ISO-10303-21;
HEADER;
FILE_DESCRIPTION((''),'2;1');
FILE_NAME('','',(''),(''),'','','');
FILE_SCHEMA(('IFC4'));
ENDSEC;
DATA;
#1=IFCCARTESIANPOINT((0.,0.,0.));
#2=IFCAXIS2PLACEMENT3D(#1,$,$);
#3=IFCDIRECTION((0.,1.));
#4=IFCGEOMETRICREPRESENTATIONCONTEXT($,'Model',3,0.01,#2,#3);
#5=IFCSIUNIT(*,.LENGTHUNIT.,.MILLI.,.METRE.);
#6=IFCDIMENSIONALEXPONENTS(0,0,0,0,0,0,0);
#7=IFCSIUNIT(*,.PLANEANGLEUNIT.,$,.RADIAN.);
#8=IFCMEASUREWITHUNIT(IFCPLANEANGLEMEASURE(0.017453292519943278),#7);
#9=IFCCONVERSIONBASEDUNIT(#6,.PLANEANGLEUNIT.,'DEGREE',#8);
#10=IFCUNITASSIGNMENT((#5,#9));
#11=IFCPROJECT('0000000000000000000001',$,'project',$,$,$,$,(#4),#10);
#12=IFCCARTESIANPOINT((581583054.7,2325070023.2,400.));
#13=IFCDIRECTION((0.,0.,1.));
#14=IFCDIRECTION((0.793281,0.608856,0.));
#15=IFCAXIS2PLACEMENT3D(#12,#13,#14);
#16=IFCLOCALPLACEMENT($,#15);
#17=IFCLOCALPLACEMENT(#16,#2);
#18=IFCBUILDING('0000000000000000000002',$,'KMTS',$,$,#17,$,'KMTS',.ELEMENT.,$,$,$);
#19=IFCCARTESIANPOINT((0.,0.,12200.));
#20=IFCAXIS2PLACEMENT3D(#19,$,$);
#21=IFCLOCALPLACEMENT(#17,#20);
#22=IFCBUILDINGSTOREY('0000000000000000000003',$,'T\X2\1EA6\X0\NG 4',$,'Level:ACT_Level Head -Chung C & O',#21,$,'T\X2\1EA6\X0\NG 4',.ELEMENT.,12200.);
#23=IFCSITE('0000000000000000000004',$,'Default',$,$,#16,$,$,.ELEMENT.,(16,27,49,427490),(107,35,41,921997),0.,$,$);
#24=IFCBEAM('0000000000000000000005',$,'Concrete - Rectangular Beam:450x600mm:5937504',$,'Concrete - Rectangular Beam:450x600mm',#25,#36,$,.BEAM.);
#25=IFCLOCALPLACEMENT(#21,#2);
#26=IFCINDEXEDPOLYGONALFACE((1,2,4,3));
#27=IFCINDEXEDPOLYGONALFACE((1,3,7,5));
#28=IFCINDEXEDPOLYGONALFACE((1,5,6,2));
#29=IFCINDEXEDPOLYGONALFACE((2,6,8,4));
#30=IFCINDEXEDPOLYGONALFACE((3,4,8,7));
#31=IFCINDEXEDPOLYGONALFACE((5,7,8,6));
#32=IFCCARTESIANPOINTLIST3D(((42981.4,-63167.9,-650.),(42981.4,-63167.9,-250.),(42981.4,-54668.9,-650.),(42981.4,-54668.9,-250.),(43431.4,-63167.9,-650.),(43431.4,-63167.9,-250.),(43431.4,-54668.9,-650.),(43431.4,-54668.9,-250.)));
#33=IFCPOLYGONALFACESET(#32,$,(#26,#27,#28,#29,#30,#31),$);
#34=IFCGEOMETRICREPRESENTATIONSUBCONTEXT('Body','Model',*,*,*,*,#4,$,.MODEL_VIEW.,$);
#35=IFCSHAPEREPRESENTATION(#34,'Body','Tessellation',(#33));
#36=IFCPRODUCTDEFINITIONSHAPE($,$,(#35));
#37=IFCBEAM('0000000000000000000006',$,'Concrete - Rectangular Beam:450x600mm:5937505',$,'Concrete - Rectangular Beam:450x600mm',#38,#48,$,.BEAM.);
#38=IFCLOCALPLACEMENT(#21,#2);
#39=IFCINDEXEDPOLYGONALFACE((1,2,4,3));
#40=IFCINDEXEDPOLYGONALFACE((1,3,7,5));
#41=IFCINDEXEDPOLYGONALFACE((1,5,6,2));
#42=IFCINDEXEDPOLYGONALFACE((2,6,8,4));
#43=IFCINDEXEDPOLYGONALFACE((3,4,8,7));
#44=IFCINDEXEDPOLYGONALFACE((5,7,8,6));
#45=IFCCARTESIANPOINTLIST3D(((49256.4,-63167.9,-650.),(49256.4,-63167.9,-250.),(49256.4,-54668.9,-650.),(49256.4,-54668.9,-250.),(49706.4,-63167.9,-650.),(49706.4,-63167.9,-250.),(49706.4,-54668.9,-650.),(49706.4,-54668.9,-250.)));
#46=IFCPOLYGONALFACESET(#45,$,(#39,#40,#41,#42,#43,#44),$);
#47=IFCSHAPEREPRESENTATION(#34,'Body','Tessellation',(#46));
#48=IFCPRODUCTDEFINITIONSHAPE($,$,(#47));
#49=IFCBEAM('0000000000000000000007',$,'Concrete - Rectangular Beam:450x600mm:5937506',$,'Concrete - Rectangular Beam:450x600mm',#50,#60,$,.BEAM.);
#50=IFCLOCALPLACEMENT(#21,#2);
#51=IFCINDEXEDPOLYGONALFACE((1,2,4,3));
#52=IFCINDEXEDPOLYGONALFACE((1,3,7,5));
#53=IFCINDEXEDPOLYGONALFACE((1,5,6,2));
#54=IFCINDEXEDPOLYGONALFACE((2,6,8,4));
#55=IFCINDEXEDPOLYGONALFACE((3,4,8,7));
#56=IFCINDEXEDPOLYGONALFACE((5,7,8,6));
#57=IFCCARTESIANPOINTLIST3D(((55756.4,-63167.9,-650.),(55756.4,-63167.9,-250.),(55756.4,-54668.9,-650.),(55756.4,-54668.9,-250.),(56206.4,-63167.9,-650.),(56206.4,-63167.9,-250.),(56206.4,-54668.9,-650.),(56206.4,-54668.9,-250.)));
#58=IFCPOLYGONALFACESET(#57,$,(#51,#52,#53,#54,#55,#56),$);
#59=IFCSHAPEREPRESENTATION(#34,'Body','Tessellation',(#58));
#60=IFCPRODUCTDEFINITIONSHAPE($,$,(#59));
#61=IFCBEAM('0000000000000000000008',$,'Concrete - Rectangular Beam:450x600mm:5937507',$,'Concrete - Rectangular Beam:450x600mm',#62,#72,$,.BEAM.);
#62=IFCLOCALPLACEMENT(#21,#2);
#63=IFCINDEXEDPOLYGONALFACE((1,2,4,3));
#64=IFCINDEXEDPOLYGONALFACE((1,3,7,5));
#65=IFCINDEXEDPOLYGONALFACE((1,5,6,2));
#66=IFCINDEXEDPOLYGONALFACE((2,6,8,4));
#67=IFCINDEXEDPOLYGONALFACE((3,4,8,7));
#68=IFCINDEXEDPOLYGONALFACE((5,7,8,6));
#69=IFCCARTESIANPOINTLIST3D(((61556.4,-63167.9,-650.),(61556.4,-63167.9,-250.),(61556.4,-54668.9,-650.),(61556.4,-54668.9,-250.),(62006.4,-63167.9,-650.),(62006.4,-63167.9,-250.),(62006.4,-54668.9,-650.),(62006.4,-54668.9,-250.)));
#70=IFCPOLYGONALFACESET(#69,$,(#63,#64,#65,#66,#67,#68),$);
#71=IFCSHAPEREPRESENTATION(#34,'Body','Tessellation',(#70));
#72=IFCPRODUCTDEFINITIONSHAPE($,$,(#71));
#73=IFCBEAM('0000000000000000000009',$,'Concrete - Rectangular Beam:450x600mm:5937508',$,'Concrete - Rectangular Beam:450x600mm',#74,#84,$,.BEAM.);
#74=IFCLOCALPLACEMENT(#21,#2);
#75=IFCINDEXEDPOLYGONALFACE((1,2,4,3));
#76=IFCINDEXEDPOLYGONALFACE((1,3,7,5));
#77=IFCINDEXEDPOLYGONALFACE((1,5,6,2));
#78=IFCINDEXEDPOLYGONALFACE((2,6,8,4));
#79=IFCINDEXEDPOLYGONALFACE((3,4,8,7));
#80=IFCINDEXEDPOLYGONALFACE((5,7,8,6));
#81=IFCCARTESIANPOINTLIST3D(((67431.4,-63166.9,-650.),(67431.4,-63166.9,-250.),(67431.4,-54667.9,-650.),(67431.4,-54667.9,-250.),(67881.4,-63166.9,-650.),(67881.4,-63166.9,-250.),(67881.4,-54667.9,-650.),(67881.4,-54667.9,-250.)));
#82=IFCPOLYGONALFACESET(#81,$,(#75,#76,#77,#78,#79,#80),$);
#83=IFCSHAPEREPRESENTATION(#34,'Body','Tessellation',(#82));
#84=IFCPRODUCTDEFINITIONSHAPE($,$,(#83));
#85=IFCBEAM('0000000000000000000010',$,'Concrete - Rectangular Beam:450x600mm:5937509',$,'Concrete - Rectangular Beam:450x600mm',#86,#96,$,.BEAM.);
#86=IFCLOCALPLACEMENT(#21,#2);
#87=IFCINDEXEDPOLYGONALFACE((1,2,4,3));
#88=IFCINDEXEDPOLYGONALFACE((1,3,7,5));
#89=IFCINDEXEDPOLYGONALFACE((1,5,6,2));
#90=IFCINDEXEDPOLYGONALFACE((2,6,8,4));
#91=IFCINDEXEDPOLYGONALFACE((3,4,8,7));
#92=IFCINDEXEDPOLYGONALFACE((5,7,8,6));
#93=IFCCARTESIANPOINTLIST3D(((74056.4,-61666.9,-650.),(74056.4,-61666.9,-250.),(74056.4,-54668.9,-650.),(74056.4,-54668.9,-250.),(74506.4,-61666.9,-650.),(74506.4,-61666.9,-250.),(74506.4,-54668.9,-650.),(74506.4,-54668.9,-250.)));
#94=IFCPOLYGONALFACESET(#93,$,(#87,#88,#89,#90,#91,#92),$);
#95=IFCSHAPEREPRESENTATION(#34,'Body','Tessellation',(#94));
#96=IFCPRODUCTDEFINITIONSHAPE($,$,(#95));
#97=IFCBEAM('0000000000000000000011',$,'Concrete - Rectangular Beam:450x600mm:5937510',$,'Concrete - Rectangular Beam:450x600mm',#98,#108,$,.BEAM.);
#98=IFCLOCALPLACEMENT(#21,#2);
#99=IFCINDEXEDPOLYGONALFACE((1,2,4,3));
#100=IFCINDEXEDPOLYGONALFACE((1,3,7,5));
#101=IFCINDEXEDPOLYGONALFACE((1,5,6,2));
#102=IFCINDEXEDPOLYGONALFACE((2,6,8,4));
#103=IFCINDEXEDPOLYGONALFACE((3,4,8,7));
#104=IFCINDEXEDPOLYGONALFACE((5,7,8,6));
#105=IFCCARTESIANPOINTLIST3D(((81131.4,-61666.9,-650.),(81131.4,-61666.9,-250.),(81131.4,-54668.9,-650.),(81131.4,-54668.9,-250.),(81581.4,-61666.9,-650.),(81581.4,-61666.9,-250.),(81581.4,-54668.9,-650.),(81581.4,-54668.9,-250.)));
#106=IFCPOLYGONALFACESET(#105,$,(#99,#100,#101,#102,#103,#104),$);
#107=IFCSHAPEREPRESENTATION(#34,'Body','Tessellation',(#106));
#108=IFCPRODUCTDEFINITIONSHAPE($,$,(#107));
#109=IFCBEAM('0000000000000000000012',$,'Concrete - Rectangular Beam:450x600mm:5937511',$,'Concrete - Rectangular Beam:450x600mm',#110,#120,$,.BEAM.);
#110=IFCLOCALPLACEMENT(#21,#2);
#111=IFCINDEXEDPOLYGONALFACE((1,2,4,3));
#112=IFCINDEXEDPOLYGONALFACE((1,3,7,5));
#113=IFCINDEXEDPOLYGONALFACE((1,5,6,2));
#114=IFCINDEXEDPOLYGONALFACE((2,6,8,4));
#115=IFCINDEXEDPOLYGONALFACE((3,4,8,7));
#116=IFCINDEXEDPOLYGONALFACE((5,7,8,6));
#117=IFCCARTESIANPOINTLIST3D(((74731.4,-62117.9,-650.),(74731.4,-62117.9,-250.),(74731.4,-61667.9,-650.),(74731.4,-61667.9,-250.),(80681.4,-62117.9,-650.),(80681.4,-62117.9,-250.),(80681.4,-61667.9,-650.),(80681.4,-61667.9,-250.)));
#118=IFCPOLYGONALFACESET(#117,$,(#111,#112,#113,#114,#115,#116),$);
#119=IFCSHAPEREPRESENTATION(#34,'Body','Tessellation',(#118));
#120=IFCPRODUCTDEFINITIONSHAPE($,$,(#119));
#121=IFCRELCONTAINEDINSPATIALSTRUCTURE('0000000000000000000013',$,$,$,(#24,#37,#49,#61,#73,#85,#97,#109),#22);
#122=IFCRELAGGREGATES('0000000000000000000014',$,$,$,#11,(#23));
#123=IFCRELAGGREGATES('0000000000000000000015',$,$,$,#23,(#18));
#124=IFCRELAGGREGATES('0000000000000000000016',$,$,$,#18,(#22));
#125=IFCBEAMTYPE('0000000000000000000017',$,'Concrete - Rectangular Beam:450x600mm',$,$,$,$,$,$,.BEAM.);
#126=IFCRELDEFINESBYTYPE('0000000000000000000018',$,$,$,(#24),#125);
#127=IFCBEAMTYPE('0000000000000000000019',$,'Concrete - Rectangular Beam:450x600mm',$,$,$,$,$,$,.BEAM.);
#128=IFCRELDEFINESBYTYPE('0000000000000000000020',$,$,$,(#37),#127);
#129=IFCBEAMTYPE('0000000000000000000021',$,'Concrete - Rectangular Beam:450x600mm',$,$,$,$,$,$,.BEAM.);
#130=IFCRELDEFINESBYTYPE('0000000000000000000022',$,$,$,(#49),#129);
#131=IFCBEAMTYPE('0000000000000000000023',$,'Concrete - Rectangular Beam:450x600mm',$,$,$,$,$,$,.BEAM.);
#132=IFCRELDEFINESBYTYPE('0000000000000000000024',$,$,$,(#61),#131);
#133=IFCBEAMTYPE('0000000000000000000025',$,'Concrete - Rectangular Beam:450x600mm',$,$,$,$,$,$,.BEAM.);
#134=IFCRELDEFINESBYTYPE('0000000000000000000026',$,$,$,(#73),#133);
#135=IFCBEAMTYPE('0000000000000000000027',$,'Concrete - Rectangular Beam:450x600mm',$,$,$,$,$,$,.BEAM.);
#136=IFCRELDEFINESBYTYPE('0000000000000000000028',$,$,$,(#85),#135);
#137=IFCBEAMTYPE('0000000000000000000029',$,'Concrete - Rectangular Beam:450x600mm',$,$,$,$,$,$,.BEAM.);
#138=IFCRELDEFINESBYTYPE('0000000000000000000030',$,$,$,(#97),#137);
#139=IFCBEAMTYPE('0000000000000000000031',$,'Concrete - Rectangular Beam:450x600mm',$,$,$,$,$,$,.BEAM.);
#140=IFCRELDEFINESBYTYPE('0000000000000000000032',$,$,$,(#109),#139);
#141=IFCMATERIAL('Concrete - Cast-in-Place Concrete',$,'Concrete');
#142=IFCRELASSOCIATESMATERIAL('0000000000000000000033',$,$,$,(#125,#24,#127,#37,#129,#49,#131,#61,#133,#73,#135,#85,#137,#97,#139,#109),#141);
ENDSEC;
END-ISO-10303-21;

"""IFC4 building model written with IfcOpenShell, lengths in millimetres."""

from ifc_helpers import new_model, entity, si_unit, converted_unit, direction, frame, origin, place, context, subcontext, project, spatial, indexed_curve, outline, extrude, source, transform, mapped, material, type_object, type_shapes, element, save


model = new_model("IFC4")

# Units and contexts
model_context = context("Model", 3, precision=0.01, world=origin(), true_north=direction((0.0, 1.0)))
body_context = subcontext(model_context, "Body", "Model", "MODEL_VIEW")
ifc_project = project(units=[si_unit("LENGTHUNIT", "METRE", prefix="MILLI"), converted_unit("PLANEANGLEUNIT", "DEGREE", entity("IfcPlaneAngleMeasure", 0.017453292519943278), si_unit("PLANEANGLEUNIT", "RADIAN"), dimensions=[0, 0, 0, 0, 0, 0, 0])], contexts=[model_context])

# Site, building, storey
site_placement = place(None, frame((581583054.7, 2325070023.2, 400.0), z_axis=(0.0, 0.0, 1.0), x_axis=(0.793281, 0.608856, 0.0)))
site = spatial("IfcSite", under=ifc_project, at=site_placement, Name="Default", CompositionType="ELEMENT", RefLatitude=(16, 27, 49, 427490), RefLongitude=(107, 35, 41, 921997), RefElevation=0.0)
building_placement = place(site_placement, origin())
building = spatial("IfcBuilding", under=site, at=building_placement, Name="KMTS", LongName="KMTS", CompositionType="ELEMENT")
storey_placement = place(building_placement, frame((0.0, 0.0, 12200.0)))
storey = spatial("IfcBuildingStorey", under=building, at=storey_placement, Name="TẦNG 4", ObjectType="Level:ACT_Level Head -Chung C & O", LongName="TẦNG 4", CompositionType="ELEMENT", Elevation=12200.0)

# Beams
ifc_material = material(Name="Concrete - Cast-in-Place Concrete", Category="Concrete")
beam_type_1 = type_object("IfcBeamType", Name="Concrete - Rectangular Beam:450x600mm", PredefinedType="BEAM", material=ifc_material)
shared_shape_1 = source(origin(), body_context, "Body", "SweptSolid", [
    extrude(outline(indexed_curve([(-225.0, -200.0), (225.0, -200.0), (225.0, 200.0), (-225.0, 200.0), (-225.0, -200.0)], self_intersect=False)), frame((43206.4, -54668.9, 11750.0), z_axis=(0.0, -1.0, 0.0), x_axis=(-1.0, 0.0, 0.0)), (0.0, 0.0, 1.0), 8499.0),
])
type_shapes(beam_type_1, [shared_shape_1])
beam_1_placement = place(storey_placement, frame((0.0, 0.0, -12200.0)))
element("IfcBeam", 1, at=beam_1_placement, inside=storey, type_object=beam_type_1, material=ifc_material, Name="Concrete - Rectangular Beam:450x600mm:5937504", ObjectType="Concrete - Rectangular Beam:450x600mm", PredefinedType="BEAM", context=body_context, shape_type="MappedRepresentation", body=[
    mapped(shared_shape_1, transform((0.0, 0.0, 0.0), scale=1.0)),
])
beam_type_2 = type_object("IfcBeamType", Name="Concrete - Rectangular Beam:450x600mm", PredefinedType="BEAM", material=ifc_material)
shared_shape_2 = source(origin(), body_context, "Body", "SweptSolid", [
    extrude(outline(indexed_curve([(-225.0, -200.0), (225.0, -200.0), (225.0, 200.0), (-225.0, 200.0), (-225.0, -200.0)], self_intersect=False)), frame((49481.4, -54668.9, 11750.0), z_axis=(0.0, -1.0, 0.0), x_axis=(-1.0, 0.0, 0.0)), (0.0, 0.0, 1.0), 8499.0),
])
type_shapes(beam_type_2, [shared_shape_2])
beam_2_placement = place(storey_placement, frame((0.0, 0.0, -12200.0)))
element("IfcBeam", 2, at=beam_2_placement, inside=storey, type_object=beam_type_2, material=ifc_material, Name="Concrete - Rectangular Beam:450x600mm:5937505", ObjectType="Concrete - Rectangular Beam:450x600mm", PredefinedType="BEAM", context=body_context, shape_type="MappedRepresentation", body=[
    mapped(shared_shape_2, transform((0.0, 0.0, 0.0), scale=1.0)),
])
beam_type_3 = type_object("IfcBeamType", Name="Concrete - Rectangular Beam:450x600mm", PredefinedType="BEAM", material=ifc_material)
shared_shape_3 = source(origin(), body_context, "Body", "SweptSolid", [
    extrude(outline(indexed_curve([(-225.0, -200.0), (225.0, -200.0), (225.0, 200.0), (-225.0, 200.0), (-225.0, -200.0)], self_intersect=False)), frame((55981.4, -54668.9, 11750.0), z_axis=(0.0, -1.0, 0.0), x_axis=(-1.0, 0.0, 0.0)), (0.0, 0.0, 1.0), 8499.0),
])
type_shapes(beam_type_3, [shared_shape_3])
beam_3_placement = place(storey_placement, frame((0.0, 0.0, -12200.0)))
element("IfcBeam", 3, at=beam_3_placement, inside=storey, type_object=beam_type_3, material=ifc_material, Name="Concrete - Rectangular Beam:450x600mm:5937506", ObjectType="Concrete - Rectangular Beam:450x600mm", PredefinedType="BEAM", context=body_context, shape_type="MappedRepresentation", body=[
    mapped(shared_shape_3, transform((0.0, 0.0, 0.0), scale=1.0)),
])
beam_type_4 = type_object("IfcBeamType", Name="Concrete - Rectangular Beam:450x600mm", PredefinedType="BEAM", material=ifc_material)
shared_shape_4 = source(origin(), body_context, "Body", "SweptSolid", [
    extrude(outline(indexed_curve([(-225.0, -200.0), (225.0, -200.0), (225.0, 200.0), (-225.0, 200.0), (-225.0, -200.0)], self_intersect=False)), frame((61781.4, -54668.9, 11750.0), z_axis=(0.0, -1.0, 0.0), x_axis=(-1.0, 0.0, 0.0)), (0.0, 0.0, 1.0), 8499.0),
])
type_shapes(beam_type_4, [shared_shape_4])
beam_4_placement = place(storey_placement, frame((0.0, 0.0, -12200.0)))
element("IfcBeam", 4, at=beam_4_placement, inside=storey, type_object=beam_type_4, material=ifc_material, Name="Concrete - Rectangular Beam:450x600mm:5937507", ObjectType="Concrete - Rectangular Beam:450x600mm", PredefinedType="BEAM", context=body_context, shape_type="MappedRepresentation", body=[
    mapped(shared_shape_4, transform((0.0, 0.0, 0.0), scale=1.0)),
])
beam_type_5 = type_object("IfcBeamType", Name="Concrete - Rectangular Beam:450x600mm", PredefinedType="BEAM", material=ifc_material)
shared_shape_5 = source(origin(), body_context, "Body", "SweptSolid", [
    extrude(outline(indexed_curve([(-225.0, -200.0), (225.0, -200.0), (225.0, 200.0), (-225.0, 200.0), (-225.0, -200.0)], self_intersect=False)), frame((67656.4, -54667.9, 11750.0), z_axis=(0.0, -1.0, 0.0), x_axis=(-1.0, 0.0, 0.0)), (0.0, 0.0, 1.0), 8499.0),
])
type_shapes(beam_type_5, [shared_shape_5])
beam_5_placement = place(storey_placement, frame((0.0, 0.0, -12200.0)))
element("IfcBeam", 5, at=beam_5_placement, inside=storey, type_object=beam_type_5, material=ifc_material, Name="Concrete - Rectangular Beam:450x600mm:5937508", ObjectType="Concrete - Rectangular Beam:450x600mm", PredefinedType="BEAM", context=body_context, shape_type="MappedRepresentation", body=[
    mapped(shared_shape_5, transform((0.0, 0.0, 0.0), scale=1.0)),
])
beam_type_6 = type_object("IfcBeamType", Name="Concrete - Rectangular Beam:450x600mm", PredefinedType="BEAM", material=ifc_material)
shared_shape_6 = source(origin(), body_context, "Body", "SweptSolid", [
    extrude(outline(indexed_curve([(-225.0, -200.0), (225.0, -200.0), (225.0, 200.0), (-225.0, 200.0), (-225.0, -200.0)], self_intersect=False)), frame((74281.4, -54668.9, 11750.0), z_axis=(0.0, -1.0, 0.0), x_axis=(-1.0, 0.0, 0.0)), (0.0, 0.0, 1.0), 6998.0),
])
type_shapes(beam_type_6, [shared_shape_6])
beam_6_placement = place(storey_placement, frame((0.0, 0.0, -12200.0)))
element("IfcBeam", 6, at=beam_6_placement, inside=storey, type_object=beam_type_6, material=ifc_material, Name="Concrete - Rectangular Beam:450x600mm:5937509", ObjectType="Concrete - Rectangular Beam:450x600mm", PredefinedType="BEAM", context=body_context, shape_type="MappedRepresentation", body=[
    mapped(shared_shape_6, transform((0.0, 0.0, 0.0), scale=1.0)),
])
beam_type_7 = type_object("IfcBeamType", Name="Concrete - Rectangular Beam:450x600mm", PredefinedType="BEAM", material=ifc_material)
shared_shape_7 = source(origin(), body_context, "Body", "SweptSolid", [
    extrude(outline(indexed_curve([(-225.0, -200.0), (225.0, -200.0), (225.0, 200.0), (-225.0, 200.0), (-225.0, -200.0)], self_intersect=False)), frame((81356.4, -54668.9, 11750.0), z_axis=(0.0, -1.0, 0.0), x_axis=(-1.0, 0.0, 0.0)), (0.0, 0.0, 1.0), 6998.0),
])
type_shapes(beam_type_7, [shared_shape_7])
beam_7_placement = place(storey_placement, frame((0.0, 0.0, -12200.0)))
element("IfcBeam", 7, at=beam_7_placement, inside=storey, type_object=beam_type_7, material=ifc_material, Name="Concrete - Rectangular Beam:450x600mm:5937510", ObjectType="Concrete - Rectangular Beam:450x600mm", PredefinedType="BEAM", context=body_context, shape_type="MappedRepresentation", body=[
    mapped(shared_shape_7, transform((0.0, 0.0, 0.0), scale=1.0)),
])
beam_type_8 = type_object("IfcBeamType", Name="Concrete - Rectangular Beam:450x600mm", PredefinedType="BEAM", material=ifc_material)
shared_shape_8 = source(origin(), body_context, "Body", "SweptSolid", [
    extrude(outline(indexed_curve([(-200.0, -225.0), (200.0, -225.0), (200.0, 225.0), (-200.0, 225.0), (-200.0, -225.0)], self_intersect=False)), frame((74731.4, -61892.9, 11750.0), z_axis=(1.0, 0.0, 0.0), x_axis=(0.0, 0.0, -1.0)), (0.0, 0.0, 1.0), 5950.0),
])
type_shapes(beam_type_8, [shared_shape_8])
beam_8_placement = place(storey_placement, frame((0.0, 0.0, -12200.0)))
element("IfcBeam", 8, at=beam_8_placement, inside=storey, type_object=beam_type_8, material=ifc_material, Name="Concrete - Rectangular Beam:450x600mm:5937511", ObjectType="Concrete - Rectangular Beam:450x600mm", PredefinedType="BEAM", context=body_context, shape_type="MappedRepresentation", body=[
    mapped(shared_shape_8, transform((0.0, 0.0, 0.0), scale=1.0)),
])

save(model, "model.ifc")
